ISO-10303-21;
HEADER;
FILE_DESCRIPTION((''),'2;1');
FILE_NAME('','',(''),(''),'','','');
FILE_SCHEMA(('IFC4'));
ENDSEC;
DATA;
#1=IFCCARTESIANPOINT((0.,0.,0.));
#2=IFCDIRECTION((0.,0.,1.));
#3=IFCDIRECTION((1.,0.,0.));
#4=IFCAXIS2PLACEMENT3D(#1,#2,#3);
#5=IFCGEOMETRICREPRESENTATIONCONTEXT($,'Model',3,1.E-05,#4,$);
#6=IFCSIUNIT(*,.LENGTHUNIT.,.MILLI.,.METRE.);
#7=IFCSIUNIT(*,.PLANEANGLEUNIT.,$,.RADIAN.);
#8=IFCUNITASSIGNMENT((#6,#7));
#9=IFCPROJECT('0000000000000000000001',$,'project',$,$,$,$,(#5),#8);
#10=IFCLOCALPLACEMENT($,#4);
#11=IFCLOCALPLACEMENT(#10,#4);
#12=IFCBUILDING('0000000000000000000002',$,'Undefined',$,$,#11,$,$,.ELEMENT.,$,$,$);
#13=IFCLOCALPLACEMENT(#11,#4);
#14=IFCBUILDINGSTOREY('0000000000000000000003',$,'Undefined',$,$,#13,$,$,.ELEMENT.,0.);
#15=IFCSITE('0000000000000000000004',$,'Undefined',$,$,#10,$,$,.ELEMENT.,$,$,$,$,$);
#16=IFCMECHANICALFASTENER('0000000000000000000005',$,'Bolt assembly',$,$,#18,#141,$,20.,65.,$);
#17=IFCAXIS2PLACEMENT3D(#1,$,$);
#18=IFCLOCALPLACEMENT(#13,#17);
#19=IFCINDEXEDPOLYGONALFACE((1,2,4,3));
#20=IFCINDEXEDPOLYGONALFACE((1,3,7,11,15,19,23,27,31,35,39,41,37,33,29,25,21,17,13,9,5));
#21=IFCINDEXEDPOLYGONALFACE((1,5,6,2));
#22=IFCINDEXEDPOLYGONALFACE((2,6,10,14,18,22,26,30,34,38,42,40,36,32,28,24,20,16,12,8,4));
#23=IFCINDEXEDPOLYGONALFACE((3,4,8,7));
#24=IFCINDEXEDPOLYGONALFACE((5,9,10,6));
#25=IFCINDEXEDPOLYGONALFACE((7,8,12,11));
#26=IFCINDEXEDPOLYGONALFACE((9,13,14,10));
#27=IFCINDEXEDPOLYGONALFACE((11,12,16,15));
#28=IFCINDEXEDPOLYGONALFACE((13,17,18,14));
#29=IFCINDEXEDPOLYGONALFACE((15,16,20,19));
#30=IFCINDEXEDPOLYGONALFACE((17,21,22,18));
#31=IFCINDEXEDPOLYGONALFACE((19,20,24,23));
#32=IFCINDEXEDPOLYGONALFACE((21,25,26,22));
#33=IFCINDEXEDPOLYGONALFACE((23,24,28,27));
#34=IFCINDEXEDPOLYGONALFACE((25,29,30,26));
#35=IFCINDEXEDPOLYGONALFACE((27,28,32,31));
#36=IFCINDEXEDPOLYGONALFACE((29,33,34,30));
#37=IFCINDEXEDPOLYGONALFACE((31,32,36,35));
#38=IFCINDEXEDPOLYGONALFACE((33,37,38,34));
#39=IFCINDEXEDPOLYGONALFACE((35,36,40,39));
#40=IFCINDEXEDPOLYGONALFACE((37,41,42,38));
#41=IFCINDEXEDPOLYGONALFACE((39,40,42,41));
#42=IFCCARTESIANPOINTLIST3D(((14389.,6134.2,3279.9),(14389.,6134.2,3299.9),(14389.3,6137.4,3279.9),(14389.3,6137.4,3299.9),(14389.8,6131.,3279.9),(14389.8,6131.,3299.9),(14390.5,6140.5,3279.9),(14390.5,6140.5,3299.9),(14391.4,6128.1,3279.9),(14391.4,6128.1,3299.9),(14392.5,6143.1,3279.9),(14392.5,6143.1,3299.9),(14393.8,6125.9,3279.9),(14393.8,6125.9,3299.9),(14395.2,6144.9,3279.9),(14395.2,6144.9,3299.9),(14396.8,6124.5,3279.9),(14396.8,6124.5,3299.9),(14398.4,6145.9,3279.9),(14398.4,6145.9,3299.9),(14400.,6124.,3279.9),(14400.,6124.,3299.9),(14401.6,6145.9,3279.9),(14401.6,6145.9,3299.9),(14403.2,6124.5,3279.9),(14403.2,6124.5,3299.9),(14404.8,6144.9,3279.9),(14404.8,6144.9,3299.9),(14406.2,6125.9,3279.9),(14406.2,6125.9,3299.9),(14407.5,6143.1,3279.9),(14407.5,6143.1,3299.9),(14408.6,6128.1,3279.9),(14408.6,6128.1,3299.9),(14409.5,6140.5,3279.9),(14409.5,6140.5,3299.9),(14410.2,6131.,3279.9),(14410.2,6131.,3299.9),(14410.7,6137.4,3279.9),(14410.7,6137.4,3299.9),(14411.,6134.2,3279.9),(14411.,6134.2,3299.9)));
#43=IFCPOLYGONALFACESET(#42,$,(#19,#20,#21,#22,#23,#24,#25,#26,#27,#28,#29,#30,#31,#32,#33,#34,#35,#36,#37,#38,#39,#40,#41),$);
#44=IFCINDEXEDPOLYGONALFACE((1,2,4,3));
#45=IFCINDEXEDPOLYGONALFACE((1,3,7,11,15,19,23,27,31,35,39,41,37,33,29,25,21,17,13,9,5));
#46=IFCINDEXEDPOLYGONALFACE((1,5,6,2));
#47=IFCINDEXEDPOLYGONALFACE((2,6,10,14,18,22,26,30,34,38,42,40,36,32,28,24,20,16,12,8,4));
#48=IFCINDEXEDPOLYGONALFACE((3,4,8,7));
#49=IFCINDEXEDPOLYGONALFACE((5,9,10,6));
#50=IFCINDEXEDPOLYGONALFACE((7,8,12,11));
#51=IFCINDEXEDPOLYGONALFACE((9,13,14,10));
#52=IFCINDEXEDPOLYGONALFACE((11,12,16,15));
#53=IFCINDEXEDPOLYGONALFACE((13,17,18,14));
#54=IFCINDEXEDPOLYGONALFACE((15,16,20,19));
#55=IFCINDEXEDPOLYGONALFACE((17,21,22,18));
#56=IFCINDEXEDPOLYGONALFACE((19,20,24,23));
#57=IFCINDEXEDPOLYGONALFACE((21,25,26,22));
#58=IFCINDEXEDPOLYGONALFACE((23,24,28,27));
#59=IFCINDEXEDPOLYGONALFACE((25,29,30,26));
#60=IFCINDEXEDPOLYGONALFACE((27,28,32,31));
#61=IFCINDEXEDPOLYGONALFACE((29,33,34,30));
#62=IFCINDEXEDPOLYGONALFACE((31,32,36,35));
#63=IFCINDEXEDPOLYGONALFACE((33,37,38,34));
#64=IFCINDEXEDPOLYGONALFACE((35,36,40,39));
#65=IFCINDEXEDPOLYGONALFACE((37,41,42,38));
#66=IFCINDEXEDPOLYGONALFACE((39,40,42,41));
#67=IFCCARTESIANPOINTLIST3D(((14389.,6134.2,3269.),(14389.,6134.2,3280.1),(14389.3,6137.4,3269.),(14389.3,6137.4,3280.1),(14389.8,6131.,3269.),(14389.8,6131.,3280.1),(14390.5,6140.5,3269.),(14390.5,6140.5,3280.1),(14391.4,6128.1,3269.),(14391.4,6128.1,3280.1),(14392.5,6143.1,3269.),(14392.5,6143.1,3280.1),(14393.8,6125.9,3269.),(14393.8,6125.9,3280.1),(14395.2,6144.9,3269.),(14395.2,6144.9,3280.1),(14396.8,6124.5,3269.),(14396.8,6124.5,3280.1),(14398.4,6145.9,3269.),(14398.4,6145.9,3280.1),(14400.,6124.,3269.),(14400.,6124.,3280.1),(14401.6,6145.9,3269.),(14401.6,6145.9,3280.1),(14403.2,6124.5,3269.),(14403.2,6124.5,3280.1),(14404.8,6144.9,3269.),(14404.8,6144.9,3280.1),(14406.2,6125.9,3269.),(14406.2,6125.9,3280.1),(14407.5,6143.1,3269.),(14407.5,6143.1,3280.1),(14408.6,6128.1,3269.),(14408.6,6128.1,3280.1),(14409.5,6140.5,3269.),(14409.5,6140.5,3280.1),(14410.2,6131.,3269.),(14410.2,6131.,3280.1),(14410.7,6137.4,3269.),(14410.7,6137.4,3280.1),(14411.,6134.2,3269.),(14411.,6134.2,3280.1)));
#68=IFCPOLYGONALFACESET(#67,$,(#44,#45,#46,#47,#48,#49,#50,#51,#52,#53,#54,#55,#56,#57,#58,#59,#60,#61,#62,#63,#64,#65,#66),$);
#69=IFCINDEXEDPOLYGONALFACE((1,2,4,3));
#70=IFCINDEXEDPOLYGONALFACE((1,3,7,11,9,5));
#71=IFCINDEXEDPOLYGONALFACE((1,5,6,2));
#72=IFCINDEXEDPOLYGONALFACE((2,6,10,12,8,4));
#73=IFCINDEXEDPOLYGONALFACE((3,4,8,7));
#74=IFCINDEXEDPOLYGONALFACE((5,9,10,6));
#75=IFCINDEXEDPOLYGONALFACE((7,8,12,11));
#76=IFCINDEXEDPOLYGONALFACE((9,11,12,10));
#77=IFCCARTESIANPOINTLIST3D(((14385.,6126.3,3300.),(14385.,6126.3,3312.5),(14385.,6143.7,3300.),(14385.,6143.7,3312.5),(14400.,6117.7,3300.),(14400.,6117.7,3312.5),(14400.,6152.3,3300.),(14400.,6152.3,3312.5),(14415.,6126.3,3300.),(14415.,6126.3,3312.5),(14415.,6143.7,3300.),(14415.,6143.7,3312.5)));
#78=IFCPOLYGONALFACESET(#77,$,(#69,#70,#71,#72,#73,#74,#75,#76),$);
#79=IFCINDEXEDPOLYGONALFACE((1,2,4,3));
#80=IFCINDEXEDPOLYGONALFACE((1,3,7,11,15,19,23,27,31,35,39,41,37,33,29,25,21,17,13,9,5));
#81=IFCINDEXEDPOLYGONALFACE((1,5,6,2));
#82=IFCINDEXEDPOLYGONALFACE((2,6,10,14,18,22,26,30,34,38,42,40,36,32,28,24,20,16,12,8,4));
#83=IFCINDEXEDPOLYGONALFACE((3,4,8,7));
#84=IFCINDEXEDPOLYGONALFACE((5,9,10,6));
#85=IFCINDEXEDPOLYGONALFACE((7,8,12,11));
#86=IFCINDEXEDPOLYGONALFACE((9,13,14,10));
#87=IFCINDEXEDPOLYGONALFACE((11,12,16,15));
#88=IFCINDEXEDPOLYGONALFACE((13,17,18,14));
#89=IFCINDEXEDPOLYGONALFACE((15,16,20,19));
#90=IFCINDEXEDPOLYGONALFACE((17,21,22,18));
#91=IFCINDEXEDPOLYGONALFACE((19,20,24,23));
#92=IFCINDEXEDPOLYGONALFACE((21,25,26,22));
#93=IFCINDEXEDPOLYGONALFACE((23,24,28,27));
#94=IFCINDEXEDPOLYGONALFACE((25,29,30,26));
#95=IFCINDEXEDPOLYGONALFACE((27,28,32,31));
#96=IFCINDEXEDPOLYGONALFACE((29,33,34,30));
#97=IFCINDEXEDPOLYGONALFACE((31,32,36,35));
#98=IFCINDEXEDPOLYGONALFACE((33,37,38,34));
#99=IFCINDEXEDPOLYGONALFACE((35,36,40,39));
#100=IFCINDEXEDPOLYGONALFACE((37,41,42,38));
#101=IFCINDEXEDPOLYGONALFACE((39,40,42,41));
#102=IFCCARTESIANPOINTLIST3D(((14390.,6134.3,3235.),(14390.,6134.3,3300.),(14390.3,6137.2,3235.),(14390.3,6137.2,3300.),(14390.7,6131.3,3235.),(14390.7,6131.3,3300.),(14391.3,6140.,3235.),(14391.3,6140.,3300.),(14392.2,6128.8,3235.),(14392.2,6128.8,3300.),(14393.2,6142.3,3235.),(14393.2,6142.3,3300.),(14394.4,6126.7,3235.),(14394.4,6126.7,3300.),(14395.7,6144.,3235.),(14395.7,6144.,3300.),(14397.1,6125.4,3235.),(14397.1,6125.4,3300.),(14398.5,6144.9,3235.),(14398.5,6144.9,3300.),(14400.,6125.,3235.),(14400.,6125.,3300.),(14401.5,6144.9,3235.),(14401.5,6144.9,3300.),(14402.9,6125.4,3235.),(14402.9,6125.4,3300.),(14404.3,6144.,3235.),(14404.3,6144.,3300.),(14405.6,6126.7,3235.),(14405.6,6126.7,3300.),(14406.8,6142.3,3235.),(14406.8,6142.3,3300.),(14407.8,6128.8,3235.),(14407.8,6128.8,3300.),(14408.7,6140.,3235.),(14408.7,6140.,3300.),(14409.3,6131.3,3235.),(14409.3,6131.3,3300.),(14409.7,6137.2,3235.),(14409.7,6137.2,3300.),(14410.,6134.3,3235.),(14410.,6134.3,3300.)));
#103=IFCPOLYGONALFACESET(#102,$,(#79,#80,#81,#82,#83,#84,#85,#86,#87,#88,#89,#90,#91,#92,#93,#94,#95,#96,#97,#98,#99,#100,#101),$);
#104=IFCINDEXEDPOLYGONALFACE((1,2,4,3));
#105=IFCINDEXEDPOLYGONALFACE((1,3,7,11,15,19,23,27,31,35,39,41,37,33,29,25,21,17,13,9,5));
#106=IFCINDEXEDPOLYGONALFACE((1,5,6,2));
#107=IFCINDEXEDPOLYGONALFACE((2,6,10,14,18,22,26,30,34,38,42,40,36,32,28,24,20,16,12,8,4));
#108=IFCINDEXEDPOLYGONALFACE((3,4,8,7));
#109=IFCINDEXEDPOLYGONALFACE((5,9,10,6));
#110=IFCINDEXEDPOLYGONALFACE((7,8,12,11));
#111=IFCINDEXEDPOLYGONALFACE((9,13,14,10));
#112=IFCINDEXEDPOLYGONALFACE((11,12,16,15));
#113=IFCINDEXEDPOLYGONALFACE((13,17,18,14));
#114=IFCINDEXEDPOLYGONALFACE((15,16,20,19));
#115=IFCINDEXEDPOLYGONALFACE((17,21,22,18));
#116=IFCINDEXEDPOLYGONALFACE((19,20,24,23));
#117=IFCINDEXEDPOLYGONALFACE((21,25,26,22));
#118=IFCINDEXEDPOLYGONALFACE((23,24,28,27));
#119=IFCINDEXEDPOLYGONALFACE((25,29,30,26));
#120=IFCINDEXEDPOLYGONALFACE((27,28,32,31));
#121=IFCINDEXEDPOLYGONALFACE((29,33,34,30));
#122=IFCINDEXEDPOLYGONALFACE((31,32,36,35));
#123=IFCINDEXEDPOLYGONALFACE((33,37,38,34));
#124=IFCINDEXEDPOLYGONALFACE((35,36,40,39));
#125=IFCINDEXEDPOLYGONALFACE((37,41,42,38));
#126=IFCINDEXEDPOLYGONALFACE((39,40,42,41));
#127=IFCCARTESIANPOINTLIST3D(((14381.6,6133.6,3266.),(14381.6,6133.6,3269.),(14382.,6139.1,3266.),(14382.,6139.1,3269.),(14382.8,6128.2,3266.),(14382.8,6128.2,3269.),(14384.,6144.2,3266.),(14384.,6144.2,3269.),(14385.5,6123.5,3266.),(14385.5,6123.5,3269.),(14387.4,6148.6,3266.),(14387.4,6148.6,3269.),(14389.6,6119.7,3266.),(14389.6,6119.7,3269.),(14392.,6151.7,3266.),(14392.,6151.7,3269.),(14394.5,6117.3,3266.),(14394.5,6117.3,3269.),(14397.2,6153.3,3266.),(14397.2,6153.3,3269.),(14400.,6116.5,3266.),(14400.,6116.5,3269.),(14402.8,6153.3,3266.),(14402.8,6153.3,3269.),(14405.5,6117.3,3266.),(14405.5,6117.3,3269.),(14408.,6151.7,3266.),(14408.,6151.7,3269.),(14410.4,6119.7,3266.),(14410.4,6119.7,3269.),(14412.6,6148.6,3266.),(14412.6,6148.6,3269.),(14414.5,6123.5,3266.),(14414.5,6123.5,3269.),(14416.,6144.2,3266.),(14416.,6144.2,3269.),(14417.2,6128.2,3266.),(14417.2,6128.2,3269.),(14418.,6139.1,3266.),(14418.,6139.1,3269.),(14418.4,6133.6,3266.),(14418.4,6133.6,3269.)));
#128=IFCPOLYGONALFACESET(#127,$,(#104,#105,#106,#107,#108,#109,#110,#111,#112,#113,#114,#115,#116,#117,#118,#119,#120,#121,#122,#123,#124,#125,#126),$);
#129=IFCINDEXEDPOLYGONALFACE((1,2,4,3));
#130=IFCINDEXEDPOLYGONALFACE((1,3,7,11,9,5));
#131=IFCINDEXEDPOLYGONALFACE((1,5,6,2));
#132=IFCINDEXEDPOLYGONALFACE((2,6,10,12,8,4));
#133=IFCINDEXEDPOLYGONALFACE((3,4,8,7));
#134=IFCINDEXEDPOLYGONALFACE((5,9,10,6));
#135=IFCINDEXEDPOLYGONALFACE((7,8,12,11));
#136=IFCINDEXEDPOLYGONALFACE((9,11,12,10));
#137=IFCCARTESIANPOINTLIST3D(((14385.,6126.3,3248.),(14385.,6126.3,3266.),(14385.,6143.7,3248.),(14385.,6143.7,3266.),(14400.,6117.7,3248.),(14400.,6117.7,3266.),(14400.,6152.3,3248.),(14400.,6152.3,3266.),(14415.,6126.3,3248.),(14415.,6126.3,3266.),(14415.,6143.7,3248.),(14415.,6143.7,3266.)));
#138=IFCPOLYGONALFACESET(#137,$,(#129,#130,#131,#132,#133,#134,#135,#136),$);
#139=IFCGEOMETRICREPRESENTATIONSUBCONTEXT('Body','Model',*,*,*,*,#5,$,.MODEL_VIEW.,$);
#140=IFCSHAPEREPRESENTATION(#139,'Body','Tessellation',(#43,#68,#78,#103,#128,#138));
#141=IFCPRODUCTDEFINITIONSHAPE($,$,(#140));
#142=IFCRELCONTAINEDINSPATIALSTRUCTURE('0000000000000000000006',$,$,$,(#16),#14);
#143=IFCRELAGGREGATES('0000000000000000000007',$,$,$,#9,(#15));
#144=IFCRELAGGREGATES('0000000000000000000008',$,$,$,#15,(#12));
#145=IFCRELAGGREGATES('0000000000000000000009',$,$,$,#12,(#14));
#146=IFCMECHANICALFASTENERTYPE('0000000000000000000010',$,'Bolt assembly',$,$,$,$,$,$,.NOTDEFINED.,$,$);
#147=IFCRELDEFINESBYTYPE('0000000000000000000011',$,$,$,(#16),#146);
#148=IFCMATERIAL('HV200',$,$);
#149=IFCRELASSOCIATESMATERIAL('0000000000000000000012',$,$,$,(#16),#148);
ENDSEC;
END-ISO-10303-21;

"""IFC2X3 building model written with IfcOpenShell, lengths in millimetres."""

from ifc_helpers import new_model, si_unit, frame, origin_with_axes, origin_2d_with_axis, place, context, subcontext, project, spatial, polyline, circle, outline, extrude, source, transform, mapped, material, type_object, element, save


model = new_model("IFC2X3")

# Units and contexts
model_context = context("Model", 3, precision=1e-05, world=origin_with_axes())
body_context = subcontext(model_context, "Body", "Model", "MODEL_VIEW")
ifc_project = project(units=[si_unit("LENGTHUNIT", "METRE", prefix="MILLI"), si_unit("PLANEANGLEUNIT", "RADIAN")], contexts=[model_context])

# Site, building, storey
site_placement = place(None, origin_with_axes())
site = spatial("IfcSite", under=ifc_project, at=site_placement, Name="Undefined", CompositionType="ELEMENT")
building_placement = place(site_placement, origin_with_axes())
building = spatial("IfcBuilding", under=site, at=building_placement, Name="Undefined", CompositionType="ELEMENT")
storey_placement = place(building_placement, origin_with_axes())
storey = spatial("IfcBuildingStorey", under=building, at=storey_placement, Name="Undefined", CompositionType="ELEMENT", Elevation=0.0)

# Mechanical fastener
ifc_material_1 = material(Name="HV200")
mechanical_fastener_type = type_object("IfcMechanicalFastenerType", Name="Bolt assembly")
shared_shape_1 = source(origin_with_axes(), body_context, "Body", "SweptSolid", [
    extrude(circle(Radius=11.0, at=origin_2d_with_axis()), frame((0.0, -19.9, 0.0), z_axis=(0.0, 1.0, 0.0), x_axis=(1.0, 0.0, 0.0)), (0.0, 0.0, 1.0), 20.0),
    extrude(circle(Radius=11.0, at=origin_2d_with_axis()), frame((0.0, -0.1, 0.0), z_axis=(0.0, 1.0, 0.0), x_axis=(1.0, 0.0, 0.0)), (0.0, 0.0, 1.0), 11.1),
    extrude(outline(polyline([(17.3, 0.0), (8.7, 15.0), (-8.7, 15.0), (-17.3, 0.0), (-8.7, -15.0), (8.7, -15.0), (17.3, 0.0)])), frame((0.0, -32.5, 0.0), z_axis=(0.0, 1.0, 0.0), x_axis=(1.0, 0.0, 0.0)), (0.0, 0.0, 1.0), 12.5),
    extrude(circle(Radius=10.0, at=origin_2d_with_axis()), frame((0.0, -20.0, 0.0), z_axis=(0.0, 1.0, 0.0), x_axis=(1.0, 0.0, 0.0)), (0.0, 0.0, 1.0), 65.0),
    extrude(circle(Radius=18.5, at=origin_2d_with_axis()), frame((0.0, 11.0, 0.0), z_axis=(0.0, 1.0, 0.0), x_axis=(1.0, 0.0, 0.0)), (0.0, 0.0, 1.0), 3.0),
    extrude(outline(polyline([(17.3, 0.0), (8.7, 15.0), (-8.7, 15.0), (-17.3, 0.0), (-8.7, -15.0), (8.7, -15.0), (17.3, 0.0)])), frame((0.0, 14.0, 0.0), z_axis=(0.0, 1.0, 0.0), x_axis=(1.0, 0.0, 0.0)), (0.0, 0.0, 1.0), 18.0),
])
for number, where, z_axis, x_axis, name in (
    (1, (14400.0, 6135.0, 3280.0), (1.0, 0.0, 0.0), (0.0, -1.0, 0.0), "Bolt assembly"),
):
    element("IfcMechanicalFastener", number, at=place(storey_placement, frame(where, z_axis=z_axis, x_axis=x_axis)), inside=storey, type_object=mechanical_fastener_type, material=ifc_material_1, Name=name, NominalDiameter=20.0, NominalLength=65.0, context=body_context, shape_type="MappedRepresentation", body=[
        mapped(shared_shape_1, transform((0.0, 0.0, 0.0))),
    ])

save(model, "model.ifc")
